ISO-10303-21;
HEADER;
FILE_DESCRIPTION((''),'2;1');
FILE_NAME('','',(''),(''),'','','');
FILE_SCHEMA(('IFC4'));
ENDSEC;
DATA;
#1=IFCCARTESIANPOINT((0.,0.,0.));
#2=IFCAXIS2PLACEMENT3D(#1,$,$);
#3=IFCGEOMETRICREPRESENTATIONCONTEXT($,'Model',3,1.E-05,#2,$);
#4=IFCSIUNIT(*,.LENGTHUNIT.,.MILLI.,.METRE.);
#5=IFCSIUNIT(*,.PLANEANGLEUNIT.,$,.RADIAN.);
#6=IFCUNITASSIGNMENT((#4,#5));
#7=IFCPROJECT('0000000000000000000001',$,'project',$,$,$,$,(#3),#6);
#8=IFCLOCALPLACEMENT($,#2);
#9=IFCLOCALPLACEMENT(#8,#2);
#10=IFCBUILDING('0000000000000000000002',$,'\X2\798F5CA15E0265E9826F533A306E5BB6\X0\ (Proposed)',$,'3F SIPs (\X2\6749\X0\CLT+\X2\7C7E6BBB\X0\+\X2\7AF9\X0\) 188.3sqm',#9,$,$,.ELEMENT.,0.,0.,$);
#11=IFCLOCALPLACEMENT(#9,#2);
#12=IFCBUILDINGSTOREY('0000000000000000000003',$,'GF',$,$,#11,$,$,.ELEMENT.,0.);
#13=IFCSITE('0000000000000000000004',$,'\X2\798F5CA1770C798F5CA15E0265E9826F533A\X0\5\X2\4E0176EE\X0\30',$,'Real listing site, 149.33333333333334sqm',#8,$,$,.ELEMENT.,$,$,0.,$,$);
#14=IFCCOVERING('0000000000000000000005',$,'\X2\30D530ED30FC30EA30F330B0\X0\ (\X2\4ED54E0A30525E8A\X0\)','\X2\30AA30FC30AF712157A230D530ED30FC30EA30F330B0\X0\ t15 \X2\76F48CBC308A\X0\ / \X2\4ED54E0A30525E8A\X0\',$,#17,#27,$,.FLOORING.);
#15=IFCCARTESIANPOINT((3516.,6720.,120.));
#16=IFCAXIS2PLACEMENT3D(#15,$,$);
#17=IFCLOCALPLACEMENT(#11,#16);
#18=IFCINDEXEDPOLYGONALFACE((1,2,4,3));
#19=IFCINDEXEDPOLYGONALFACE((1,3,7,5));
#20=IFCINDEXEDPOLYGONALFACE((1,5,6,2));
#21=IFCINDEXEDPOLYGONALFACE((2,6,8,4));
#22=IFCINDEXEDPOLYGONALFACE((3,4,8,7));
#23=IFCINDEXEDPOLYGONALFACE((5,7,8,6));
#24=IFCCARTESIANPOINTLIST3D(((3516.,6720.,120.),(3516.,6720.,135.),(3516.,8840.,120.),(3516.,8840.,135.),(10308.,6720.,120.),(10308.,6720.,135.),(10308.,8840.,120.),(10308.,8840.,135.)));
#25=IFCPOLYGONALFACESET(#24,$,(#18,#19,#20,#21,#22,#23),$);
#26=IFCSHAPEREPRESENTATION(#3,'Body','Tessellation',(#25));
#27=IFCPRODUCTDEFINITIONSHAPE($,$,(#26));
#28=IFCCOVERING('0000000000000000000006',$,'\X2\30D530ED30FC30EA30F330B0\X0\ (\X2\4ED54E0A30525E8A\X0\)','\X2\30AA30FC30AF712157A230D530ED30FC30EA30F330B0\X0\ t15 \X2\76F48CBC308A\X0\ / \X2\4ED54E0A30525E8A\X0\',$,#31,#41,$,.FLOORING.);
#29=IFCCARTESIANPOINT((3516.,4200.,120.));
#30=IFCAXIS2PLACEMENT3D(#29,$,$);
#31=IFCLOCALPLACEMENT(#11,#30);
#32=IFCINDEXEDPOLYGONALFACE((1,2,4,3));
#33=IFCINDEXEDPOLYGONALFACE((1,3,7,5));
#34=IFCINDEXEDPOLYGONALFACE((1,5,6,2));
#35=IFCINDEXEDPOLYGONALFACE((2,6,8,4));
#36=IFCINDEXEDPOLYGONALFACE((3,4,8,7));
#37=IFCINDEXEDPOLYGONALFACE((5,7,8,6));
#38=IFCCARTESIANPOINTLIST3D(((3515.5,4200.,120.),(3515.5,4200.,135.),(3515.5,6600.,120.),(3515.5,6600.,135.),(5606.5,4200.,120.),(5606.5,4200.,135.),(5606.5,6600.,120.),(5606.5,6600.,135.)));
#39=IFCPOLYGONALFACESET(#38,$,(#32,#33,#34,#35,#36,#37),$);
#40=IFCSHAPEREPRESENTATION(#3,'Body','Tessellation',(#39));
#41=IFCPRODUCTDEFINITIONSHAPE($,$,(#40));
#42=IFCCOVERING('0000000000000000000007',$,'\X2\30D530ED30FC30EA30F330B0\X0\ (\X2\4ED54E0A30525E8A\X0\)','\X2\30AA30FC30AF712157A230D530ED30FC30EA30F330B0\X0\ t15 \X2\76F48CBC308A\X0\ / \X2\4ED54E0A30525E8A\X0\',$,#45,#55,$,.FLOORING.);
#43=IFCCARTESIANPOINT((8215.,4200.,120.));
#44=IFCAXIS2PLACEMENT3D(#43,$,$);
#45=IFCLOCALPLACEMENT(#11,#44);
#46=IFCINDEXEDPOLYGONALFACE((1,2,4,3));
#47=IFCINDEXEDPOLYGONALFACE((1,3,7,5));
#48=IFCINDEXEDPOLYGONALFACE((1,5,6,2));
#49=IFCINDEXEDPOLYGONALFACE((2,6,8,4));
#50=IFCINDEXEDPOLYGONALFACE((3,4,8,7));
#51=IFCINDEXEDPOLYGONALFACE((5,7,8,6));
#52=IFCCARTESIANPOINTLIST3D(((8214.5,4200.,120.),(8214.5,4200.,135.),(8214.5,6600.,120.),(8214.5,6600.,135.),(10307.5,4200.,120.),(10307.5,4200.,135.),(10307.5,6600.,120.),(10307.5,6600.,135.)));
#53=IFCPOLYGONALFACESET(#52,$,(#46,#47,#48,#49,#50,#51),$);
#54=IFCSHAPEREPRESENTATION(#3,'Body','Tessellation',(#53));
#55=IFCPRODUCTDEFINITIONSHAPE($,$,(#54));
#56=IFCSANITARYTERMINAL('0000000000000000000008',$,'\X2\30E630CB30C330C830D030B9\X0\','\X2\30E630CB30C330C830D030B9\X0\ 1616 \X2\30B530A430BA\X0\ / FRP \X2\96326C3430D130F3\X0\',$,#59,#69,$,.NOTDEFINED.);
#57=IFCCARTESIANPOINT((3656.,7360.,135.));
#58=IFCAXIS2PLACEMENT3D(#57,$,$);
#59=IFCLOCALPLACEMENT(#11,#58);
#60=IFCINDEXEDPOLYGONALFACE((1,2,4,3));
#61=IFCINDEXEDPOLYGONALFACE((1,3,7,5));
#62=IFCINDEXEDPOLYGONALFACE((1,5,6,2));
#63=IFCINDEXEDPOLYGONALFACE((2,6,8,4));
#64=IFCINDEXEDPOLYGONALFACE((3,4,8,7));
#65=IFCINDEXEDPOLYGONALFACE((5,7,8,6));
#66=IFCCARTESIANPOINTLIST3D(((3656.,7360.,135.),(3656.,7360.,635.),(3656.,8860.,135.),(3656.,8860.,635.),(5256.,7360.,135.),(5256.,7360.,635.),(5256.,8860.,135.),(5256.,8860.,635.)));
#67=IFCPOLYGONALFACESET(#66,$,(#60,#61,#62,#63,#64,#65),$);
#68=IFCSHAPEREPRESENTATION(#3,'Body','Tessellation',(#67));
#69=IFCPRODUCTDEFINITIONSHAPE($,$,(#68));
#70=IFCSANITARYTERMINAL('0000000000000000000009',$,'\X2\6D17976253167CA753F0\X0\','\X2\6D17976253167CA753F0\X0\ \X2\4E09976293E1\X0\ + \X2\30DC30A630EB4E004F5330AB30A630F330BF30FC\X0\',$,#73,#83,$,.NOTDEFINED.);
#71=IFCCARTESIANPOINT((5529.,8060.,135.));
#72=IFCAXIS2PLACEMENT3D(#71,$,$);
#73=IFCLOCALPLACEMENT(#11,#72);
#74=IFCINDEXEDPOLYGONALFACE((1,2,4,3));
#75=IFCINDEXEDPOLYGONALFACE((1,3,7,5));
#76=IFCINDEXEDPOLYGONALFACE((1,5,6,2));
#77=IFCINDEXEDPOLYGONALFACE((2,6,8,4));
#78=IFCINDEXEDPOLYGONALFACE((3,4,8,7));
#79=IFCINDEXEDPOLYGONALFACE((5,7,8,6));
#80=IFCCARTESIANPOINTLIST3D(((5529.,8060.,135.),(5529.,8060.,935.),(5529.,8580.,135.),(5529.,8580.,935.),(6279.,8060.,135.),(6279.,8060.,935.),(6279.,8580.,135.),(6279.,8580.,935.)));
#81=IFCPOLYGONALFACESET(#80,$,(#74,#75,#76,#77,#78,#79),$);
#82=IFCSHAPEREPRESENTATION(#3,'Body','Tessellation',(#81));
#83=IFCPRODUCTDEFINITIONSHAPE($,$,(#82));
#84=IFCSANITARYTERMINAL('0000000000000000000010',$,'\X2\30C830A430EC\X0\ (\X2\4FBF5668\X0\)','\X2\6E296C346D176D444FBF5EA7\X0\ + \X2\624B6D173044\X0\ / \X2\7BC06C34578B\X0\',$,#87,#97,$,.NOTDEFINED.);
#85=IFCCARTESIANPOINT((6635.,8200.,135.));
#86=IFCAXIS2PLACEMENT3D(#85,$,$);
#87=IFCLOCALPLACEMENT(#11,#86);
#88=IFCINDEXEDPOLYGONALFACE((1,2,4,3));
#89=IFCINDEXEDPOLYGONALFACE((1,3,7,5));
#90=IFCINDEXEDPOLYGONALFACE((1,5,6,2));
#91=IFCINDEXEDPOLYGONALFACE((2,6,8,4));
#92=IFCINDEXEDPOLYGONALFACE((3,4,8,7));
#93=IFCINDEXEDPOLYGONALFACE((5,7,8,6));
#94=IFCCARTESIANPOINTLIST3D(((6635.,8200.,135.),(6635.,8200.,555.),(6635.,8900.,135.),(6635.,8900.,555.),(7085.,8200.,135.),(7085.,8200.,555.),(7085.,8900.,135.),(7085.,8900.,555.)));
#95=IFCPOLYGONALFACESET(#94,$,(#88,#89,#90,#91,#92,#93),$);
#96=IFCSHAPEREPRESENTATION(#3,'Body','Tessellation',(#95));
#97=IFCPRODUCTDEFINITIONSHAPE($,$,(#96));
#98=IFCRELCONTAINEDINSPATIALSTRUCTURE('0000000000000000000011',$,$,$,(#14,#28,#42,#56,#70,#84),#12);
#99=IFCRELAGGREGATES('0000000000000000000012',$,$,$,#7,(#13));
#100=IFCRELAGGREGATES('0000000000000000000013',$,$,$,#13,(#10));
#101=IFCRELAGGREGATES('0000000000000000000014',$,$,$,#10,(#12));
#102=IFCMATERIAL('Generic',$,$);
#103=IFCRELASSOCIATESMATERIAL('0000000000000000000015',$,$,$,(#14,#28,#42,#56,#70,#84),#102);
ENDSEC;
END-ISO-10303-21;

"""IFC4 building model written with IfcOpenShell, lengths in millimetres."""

from ifc_helpers import new_model, si_unit, frame, frame_2d, origin, place, context, project, spatial, rectangle, extrude, material, element, save


model = new_model("IFC4")

# Units and contexts
model_context = context("Model", 3, precision=1e-05, world=origin())
ifc_project = project(units=[si_unit("LENGTHUNIT", "METRE", prefix="MILLI"), si_unit("PLANEANGLEUNIT", "RADIAN")], contexts=[model_context])

# Site, building, storey
site_placement = place(None, origin())
site = spatial("IfcSite", under=ifc_project, at=site_placement, Name="福岡県福岡市早良区5丁目30", ObjectType="Real listing site, 149.33333333333334sqm", CompositionType="ELEMENT", RefElevation=0.0)
building_placement = place(site_placement, origin())
building = spatial("IfcBuilding", under=site, at=building_placement, Name="福岡市早良区の家 (Proposed)", ObjectType="3F SIPs (杉CLT+籾殻+竹) 188.3sqm", CompositionType="ELEMENT", ElevationOfRefHeight=0.0, ElevationOfTerrain=0.0)
storey_placement = place(building_placement, origin())
storey = spatial("IfcBuildingStorey", under=building, at=storey_placement, Name="GF", CompositionType="ELEMENT", Elevation=0.0)

# Coverings
ifc_material_1 = material(Name="Generic")
covering_1_placement = place(storey_placement, frame((3516.0, 6720.0, 120.0)))
element("IfcCovering", 1, at=covering_1_placement, inside=storey, material=ifc_material_1, Name="フローリング (仕上げ床)", Description="オーク無垢フローリング t15 直貼り / 仕上げ床", PredefinedType="FLOORING", context=model_context, shape_type="SweptSolid", body=[
    extrude(rectangle(XDim=6792.0, YDim=2120.0, at=frame_2d((3396.0, 1060.0))), frame((3516.0, 6720.0, 120.0)), (0.0, 0.0, 1.0), 15.0),
])
covering_2_placement = place(storey_placement, frame((3516.0, 4200.0, 120.0)))
element("IfcCovering", 2, at=covering_2_placement, inside=storey, material=ifc_material_1, Name="フローリング (仕上げ床)", Description="オーク無垢フローリング t15 直貼り / 仕上げ床", PredefinedType="FLOORING", context=model_context, shape_type="SweptSolid", body=[
    extrude(rectangle(XDim=2091.0, YDim=2400.0, at=frame_2d((1045.0, 1200.0))), frame((3516.0, 4200.0, 120.0)), (0.0, 0.0, 1.0), 15.0),
])
covering_3_placement = place(storey_placement, frame((8215.0, 4200.0, 120.0)))
element("IfcCovering", 3, at=covering_3_placement, inside=storey, material=ifc_material_1, Name="フローリング (仕上げ床)", Description="オーク無垢フローリング t15 直貼り / 仕上げ床", PredefinedType="FLOORING", context=model_context, shape_type="SweptSolid", body=[
    extrude(rectangle(XDim=2093.0, YDim=2400.0, at=frame_2d((1046.0, 1200.0))), frame((8215.0, 4200.0, 120.0)), (0.0, 0.0, 1.0), 15.0),
])

# Sanitary terminals
sanitary_terminal_1_placement = place(storey_placement, frame((3656.0, 7360.0, 135.0)))
element("IfcSanitaryTerminal", 4, at=sanitary_terminal_1_placement, inside=storey, material=ifc_material_1, Name="ユニットバス", Description="ユニットバス 1616 サイズ / FRP 防水パン", PredefinedType="NOTDEFINED", context=model_context, shape_type="SweptSolid", body=[
    extrude(rectangle(XDim=1600.0, YDim=1500.0, at=frame_2d((800.0, 750.0))), frame((3656.0, 7360.0, 135.0)), (0.0, 0.0, 1.0), 500.0),
])
sanitary_terminal_2_placement = place(storey_placement, frame((5529.0, 8060.0, 135.0)))
element("IfcSanitaryTerminal", 5, at=sanitary_terminal_2_placement, inside=storey, material=ifc_material_1, Name="洗面化粧台", Description="洗面化粧台 三面鏡 + ボウル一体カウンター", PredefinedType="NOTDEFINED", context=model_context, shape_type="SweptSolid", body=[
    extrude(rectangle(XDim=750.0, YDim=520.0, at=frame_2d((375.0, 260.0))), frame((5529.0, 8060.0, 135.0)), (0.0, 0.0, 1.0), 800.0),
])
sanitary_terminal_3_placement = place(storey_placement, frame((6635.0, 8200.0, 135.0)))
element("IfcSanitaryTerminal", 6, at=sanitary_terminal_3_placement, inside=storey, material=ifc_material_1, Name="トイレ (便器)", Description="温水洗浄便座 + 手洗い / 節水型", PredefinedType="NOTDEFINED", context=model_context, shape_type="SweptSolid", body=[
    extrude(rectangle(XDim=450.0, YDim=700.0, at=frame_2d((225.0, 350.0))), frame((6635.0, 8200.0, 135.0)), (0.0, 0.0, 1.0), 420.0),
])

save(model, "model.ifc")
